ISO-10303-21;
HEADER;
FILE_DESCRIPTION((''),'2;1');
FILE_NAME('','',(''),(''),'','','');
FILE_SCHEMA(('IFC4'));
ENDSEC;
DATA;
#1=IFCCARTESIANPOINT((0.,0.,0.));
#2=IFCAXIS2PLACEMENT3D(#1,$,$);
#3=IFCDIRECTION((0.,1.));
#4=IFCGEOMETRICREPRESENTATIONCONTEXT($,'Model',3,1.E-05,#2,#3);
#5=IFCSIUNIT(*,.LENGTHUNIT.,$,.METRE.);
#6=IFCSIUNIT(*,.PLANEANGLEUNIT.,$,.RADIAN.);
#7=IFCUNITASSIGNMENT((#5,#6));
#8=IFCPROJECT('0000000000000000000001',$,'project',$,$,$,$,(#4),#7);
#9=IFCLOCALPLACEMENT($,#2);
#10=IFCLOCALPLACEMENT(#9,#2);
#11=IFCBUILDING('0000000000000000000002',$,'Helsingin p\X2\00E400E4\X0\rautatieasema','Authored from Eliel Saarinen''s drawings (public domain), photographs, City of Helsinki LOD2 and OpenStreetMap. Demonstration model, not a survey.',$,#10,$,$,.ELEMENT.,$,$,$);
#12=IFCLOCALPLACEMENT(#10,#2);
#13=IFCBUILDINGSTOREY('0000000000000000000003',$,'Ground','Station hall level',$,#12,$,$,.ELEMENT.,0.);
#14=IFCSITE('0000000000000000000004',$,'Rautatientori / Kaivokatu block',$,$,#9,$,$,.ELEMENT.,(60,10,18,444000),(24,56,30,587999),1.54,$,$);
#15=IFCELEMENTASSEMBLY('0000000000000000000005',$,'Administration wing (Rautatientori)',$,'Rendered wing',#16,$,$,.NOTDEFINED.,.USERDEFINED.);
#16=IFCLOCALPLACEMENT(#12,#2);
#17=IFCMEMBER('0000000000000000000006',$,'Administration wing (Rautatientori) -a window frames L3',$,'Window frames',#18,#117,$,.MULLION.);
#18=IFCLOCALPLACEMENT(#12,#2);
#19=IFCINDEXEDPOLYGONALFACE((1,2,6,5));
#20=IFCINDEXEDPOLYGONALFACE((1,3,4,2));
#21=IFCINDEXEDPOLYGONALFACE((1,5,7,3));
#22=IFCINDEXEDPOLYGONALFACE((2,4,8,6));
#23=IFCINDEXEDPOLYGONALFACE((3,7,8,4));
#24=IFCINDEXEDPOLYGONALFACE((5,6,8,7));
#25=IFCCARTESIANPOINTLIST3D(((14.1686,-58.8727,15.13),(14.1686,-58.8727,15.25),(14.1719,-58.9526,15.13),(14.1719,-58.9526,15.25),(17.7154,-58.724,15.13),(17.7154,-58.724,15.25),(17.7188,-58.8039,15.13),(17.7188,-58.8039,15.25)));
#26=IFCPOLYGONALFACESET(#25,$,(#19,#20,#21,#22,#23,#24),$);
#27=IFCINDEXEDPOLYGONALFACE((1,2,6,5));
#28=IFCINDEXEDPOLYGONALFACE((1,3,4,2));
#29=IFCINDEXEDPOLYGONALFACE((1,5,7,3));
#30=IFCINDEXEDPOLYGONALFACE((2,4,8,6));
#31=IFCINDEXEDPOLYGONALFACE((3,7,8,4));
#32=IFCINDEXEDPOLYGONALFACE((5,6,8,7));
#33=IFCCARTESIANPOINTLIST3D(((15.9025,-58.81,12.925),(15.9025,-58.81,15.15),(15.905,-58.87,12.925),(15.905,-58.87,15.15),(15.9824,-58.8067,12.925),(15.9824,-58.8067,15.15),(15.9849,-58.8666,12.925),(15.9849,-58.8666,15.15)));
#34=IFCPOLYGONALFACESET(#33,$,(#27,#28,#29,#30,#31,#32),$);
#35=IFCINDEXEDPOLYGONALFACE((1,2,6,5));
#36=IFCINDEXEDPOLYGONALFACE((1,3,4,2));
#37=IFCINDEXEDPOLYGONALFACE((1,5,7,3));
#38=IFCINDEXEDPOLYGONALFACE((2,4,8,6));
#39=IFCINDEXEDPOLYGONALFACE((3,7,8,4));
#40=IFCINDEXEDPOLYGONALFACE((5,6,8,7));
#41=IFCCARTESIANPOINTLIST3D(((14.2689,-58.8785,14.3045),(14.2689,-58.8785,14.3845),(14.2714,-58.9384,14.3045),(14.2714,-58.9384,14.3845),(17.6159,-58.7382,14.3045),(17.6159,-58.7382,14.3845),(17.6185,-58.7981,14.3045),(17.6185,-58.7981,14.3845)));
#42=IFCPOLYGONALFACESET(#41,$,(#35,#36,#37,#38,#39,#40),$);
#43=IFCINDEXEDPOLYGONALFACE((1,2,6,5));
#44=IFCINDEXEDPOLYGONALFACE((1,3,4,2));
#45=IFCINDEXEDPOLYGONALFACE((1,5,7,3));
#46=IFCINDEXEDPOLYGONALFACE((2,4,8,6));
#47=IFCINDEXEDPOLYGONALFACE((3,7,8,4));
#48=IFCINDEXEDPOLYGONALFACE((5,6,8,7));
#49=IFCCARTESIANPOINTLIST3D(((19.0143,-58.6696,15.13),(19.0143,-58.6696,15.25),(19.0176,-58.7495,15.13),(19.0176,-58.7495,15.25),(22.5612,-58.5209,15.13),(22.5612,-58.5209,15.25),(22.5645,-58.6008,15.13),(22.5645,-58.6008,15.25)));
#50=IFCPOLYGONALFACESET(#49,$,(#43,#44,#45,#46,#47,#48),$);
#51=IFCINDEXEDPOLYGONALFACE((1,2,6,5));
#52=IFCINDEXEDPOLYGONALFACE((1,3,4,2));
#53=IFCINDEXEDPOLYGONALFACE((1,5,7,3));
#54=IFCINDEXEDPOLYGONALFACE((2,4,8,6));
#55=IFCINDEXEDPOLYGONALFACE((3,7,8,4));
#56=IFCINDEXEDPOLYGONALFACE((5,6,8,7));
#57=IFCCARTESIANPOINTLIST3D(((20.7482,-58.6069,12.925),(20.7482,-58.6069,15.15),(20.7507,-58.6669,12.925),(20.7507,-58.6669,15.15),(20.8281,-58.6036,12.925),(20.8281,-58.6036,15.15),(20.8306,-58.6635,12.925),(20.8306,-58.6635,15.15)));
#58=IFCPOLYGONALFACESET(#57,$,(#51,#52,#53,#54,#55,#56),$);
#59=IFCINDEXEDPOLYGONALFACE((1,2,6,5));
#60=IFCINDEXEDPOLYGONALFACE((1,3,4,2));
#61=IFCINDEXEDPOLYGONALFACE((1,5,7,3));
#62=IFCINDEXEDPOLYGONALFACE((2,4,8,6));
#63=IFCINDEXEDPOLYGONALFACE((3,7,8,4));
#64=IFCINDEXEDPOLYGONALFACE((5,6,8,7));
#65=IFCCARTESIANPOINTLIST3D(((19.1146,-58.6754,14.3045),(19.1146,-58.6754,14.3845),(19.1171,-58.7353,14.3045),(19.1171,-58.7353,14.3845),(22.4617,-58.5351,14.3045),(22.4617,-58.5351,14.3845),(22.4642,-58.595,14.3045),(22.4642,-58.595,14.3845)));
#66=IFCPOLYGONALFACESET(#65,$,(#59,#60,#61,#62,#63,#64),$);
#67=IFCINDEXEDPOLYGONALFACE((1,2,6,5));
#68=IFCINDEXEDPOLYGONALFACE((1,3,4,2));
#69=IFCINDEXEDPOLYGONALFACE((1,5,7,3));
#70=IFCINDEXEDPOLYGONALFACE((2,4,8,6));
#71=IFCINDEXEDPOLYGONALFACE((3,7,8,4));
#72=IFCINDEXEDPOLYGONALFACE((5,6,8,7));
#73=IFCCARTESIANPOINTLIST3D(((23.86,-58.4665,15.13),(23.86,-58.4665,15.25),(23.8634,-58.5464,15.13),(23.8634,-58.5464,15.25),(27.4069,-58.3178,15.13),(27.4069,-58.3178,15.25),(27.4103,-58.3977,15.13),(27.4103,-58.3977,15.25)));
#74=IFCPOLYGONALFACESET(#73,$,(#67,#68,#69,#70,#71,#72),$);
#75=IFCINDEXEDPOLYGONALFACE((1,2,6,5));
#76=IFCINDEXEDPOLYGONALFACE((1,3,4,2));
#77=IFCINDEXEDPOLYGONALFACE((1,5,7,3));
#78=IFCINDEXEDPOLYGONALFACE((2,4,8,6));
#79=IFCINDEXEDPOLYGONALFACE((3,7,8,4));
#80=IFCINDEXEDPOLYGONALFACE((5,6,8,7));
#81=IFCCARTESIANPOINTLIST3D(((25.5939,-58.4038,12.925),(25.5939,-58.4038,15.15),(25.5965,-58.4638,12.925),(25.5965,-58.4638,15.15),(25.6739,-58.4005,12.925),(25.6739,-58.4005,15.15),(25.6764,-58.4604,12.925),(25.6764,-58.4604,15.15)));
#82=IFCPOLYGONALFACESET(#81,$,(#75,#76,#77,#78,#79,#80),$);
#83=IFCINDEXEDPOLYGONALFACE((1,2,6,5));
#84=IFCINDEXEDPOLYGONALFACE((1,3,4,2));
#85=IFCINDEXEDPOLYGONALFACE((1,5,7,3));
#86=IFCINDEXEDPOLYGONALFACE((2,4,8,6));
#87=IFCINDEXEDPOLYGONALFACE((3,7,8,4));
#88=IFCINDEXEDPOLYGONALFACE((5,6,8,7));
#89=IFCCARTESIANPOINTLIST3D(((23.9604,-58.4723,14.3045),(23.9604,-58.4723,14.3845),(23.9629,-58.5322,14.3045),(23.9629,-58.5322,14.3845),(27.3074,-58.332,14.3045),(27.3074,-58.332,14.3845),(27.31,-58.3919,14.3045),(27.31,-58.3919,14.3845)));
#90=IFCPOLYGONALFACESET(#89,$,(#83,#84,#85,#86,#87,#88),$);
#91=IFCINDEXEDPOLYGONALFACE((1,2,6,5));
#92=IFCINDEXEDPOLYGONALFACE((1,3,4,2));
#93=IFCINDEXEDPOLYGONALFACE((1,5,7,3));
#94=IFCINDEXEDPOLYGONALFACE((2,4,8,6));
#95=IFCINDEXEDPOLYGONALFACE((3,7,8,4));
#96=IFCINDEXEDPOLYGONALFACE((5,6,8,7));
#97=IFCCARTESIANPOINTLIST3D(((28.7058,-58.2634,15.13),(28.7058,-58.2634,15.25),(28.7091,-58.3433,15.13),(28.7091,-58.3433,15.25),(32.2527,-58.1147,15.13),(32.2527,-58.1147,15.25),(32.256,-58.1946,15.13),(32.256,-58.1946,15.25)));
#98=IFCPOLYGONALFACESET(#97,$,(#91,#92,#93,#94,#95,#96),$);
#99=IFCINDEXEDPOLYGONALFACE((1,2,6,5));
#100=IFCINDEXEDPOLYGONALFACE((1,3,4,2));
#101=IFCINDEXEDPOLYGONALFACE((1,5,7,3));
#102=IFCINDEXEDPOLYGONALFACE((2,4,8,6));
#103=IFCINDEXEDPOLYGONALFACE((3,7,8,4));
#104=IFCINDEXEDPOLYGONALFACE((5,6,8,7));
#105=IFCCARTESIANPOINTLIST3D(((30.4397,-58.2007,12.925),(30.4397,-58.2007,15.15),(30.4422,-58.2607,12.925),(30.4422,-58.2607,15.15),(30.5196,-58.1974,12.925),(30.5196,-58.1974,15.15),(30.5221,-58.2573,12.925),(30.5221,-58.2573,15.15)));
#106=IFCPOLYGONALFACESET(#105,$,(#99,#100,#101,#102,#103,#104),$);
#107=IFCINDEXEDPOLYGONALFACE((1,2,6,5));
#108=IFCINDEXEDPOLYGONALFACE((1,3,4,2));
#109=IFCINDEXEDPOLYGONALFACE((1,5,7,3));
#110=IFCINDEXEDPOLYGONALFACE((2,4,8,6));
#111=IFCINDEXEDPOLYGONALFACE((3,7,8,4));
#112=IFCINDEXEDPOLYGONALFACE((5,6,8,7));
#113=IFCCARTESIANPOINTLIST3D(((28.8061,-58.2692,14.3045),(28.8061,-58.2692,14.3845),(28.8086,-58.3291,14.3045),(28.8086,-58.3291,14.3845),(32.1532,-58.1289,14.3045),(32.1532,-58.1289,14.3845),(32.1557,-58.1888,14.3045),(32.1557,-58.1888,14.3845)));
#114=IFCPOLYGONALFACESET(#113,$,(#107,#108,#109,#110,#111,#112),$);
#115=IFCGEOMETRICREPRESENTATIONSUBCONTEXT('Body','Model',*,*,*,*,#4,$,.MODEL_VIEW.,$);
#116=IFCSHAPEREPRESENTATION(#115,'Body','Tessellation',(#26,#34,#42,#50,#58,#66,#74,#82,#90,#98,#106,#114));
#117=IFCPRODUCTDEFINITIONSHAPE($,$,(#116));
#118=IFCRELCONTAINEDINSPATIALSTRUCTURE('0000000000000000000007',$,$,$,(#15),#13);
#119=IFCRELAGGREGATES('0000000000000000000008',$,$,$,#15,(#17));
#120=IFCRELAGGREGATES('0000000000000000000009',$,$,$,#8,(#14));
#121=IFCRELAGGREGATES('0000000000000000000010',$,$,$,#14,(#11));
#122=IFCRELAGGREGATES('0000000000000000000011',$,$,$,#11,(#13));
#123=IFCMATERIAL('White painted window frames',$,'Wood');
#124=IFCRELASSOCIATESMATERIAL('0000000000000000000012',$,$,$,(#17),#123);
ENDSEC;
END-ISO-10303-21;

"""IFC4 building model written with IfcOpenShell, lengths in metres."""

from ifc_helpers import new_model, si_unit, direction, frame, frame_2d, origin, place, context, subcontext, project, spatial, rectangle, extrude, material, element, aggregate, save


model = new_model("IFC4")

# Units and contexts
model_context = context("Model", 3, precision=1e-05, world=origin(), true_north=direction((0.0, 1.0)))
body_context = subcontext(model_context, "Body", "Model", "MODEL_VIEW")
ifc_project = project(units=[si_unit("LENGTHUNIT", "METRE"), si_unit("PLANEANGLEUNIT", "RADIAN")], contexts=[model_context])

# Site, building, storey
site_placement = place(None, origin())
site = spatial("IfcSite", under=ifc_project, at=site_placement, Name="Rautatientori / Kaivokatu block", CompositionType="ELEMENT", RefLatitude=(60, 10, 18, 444000), RefLongitude=(24, 56, 30, 587999), RefElevation=1.54)
building_placement = place(site_placement, origin())
building = spatial("IfcBuilding", under=site, at=building_placement, Name="Helsingin päärautatieasema", Description="Authored from Eliel Saarinen's drawings (public domain), photographs, City of Helsinki LOD2 and OpenStreetMap. Demonstration model, not a survey.", CompositionType="ELEMENT")
storey_placement = place(building_placement, origin())
storey = spatial("IfcBuildingStorey", under=building, at=storey_placement, Name="Ground", Description="Station hall level", CompositionType="ELEMENT", Elevation=0.0)

# Element assembly, member
assembly_placement = place(building_placement, origin())
assembly = element("IfcElementAssembly", 1, at=assembly_placement, inside=storey, Name="Administration wing (Rautatientori)", ObjectType="Rendered wing", AssemblyPlace="NOTDEFINED", PredefinedType="USERDEFINED")
ifc_material_1 = material(Name="White painted window frames", Category="Wood")
member_1_placement = place(building_placement, origin())
member_1 = element("IfcMember", 2, at=member_1_placement, material=ifc_material_1, Name="Administration wing (Rautatientori) -a window frames L3", ObjectType="Window frames", PredefinedType="MULLION", context=body_context, shape_type="SweptSolid", body=[
    extrude(rectangle(XDim=3.55, YDim=0.08, at=frame_2d((0.0, 0.0), x_axis=(0.999123, 0.041876))), frame((15.9437, -58.8383, 15.13)), (0.0, 0.0, 1.0), 0.12),
    extrude(rectangle(XDim=0.08, YDim=0.06, at=frame_2d((0.0, 0.0), x_axis=(0.999123, 0.041876))), frame((15.9437, -58.8383, 12.925)), (0.0, 0.0, 1.0), 2.225),
    extrude(rectangle(XDim=3.35, YDim=0.06, at=frame_2d((0.0, 0.0), x_axis=(0.999123, 0.041876))), frame((15.9437, -58.8383, 14.3045)), (0.0, 0.0, 1.0), 0.08),
    extrude(rectangle(XDim=3.55, YDim=0.08, at=frame_2d((0.0, 0.0), x_axis=(0.999123, 0.041876))), frame((20.7894, -58.6352, 15.13)), (0.0, 0.0, 1.0), 0.12),
    extrude(rectangle(XDim=0.08, YDim=0.06, at=frame_2d((0.0, 0.0), x_axis=(0.999123, 0.041876))), frame((20.7894, -58.6352, 12.925)), (0.0, 0.0, 1.0), 2.225),
    extrude(rectangle(XDim=3.35, YDim=0.06, at=frame_2d((0.0, 0.0), x_axis=(0.999123, 0.041876))), frame((20.7894, -58.6352, 14.3045)), (0.0, 0.0, 1.0), 0.08),
    extrude(rectangle(XDim=3.55, YDim=0.08, at=frame_2d((0.0, 0.0), x_axis=(0.999123, 0.041876))), frame((25.6352, -58.4321, 15.13)), (0.0, 0.0, 1.0), 0.12),
    extrude(rectangle(XDim=0.08, YDim=0.06, at=frame_2d((0.0, 0.0), x_axis=(0.999123, 0.041876))), frame((25.6352, -58.4321, 12.925)), (0.0, 0.0, 1.0), 2.225),
    extrude(rectangle(XDim=3.35, YDim=0.06, at=frame_2d((0.0, 0.0), x_axis=(0.999123, 0.041876))), frame((25.6352, -58.4321, 14.3045)), (0.0, 0.0, 1.0), 0.08),
    extrude(rectangle(XDim=3.55, YDim=0.08, at=frame_2d((0.0, 0.0), x_axis=(0.999123, 0.041876))), frame((30.4809, -58.229, 15.13)), (0.0, 0.0, 1.0), 0.12),
    extrude(rectangle(XDim=0.08, YDim=0.06, at=frame_2d((0.0, 0.0), x_axis=(0.999123, 0.041876))), frame((30.4809, -58.229, 12.925)), (0.0, 0.0, 1.0), 2.225),
    extrude(rectangle(XDim=3.35, YDim=0.06, at=frame_2d((0.0, 0.0), x_axis=(0.999123, 0.041876))), frame((30.4809, -58.229, 14.3045)), (0.0, 0.0, 1.0), 0.08),
])
aggregate(assembly, [member_1])

save(model, "model.ifc")
